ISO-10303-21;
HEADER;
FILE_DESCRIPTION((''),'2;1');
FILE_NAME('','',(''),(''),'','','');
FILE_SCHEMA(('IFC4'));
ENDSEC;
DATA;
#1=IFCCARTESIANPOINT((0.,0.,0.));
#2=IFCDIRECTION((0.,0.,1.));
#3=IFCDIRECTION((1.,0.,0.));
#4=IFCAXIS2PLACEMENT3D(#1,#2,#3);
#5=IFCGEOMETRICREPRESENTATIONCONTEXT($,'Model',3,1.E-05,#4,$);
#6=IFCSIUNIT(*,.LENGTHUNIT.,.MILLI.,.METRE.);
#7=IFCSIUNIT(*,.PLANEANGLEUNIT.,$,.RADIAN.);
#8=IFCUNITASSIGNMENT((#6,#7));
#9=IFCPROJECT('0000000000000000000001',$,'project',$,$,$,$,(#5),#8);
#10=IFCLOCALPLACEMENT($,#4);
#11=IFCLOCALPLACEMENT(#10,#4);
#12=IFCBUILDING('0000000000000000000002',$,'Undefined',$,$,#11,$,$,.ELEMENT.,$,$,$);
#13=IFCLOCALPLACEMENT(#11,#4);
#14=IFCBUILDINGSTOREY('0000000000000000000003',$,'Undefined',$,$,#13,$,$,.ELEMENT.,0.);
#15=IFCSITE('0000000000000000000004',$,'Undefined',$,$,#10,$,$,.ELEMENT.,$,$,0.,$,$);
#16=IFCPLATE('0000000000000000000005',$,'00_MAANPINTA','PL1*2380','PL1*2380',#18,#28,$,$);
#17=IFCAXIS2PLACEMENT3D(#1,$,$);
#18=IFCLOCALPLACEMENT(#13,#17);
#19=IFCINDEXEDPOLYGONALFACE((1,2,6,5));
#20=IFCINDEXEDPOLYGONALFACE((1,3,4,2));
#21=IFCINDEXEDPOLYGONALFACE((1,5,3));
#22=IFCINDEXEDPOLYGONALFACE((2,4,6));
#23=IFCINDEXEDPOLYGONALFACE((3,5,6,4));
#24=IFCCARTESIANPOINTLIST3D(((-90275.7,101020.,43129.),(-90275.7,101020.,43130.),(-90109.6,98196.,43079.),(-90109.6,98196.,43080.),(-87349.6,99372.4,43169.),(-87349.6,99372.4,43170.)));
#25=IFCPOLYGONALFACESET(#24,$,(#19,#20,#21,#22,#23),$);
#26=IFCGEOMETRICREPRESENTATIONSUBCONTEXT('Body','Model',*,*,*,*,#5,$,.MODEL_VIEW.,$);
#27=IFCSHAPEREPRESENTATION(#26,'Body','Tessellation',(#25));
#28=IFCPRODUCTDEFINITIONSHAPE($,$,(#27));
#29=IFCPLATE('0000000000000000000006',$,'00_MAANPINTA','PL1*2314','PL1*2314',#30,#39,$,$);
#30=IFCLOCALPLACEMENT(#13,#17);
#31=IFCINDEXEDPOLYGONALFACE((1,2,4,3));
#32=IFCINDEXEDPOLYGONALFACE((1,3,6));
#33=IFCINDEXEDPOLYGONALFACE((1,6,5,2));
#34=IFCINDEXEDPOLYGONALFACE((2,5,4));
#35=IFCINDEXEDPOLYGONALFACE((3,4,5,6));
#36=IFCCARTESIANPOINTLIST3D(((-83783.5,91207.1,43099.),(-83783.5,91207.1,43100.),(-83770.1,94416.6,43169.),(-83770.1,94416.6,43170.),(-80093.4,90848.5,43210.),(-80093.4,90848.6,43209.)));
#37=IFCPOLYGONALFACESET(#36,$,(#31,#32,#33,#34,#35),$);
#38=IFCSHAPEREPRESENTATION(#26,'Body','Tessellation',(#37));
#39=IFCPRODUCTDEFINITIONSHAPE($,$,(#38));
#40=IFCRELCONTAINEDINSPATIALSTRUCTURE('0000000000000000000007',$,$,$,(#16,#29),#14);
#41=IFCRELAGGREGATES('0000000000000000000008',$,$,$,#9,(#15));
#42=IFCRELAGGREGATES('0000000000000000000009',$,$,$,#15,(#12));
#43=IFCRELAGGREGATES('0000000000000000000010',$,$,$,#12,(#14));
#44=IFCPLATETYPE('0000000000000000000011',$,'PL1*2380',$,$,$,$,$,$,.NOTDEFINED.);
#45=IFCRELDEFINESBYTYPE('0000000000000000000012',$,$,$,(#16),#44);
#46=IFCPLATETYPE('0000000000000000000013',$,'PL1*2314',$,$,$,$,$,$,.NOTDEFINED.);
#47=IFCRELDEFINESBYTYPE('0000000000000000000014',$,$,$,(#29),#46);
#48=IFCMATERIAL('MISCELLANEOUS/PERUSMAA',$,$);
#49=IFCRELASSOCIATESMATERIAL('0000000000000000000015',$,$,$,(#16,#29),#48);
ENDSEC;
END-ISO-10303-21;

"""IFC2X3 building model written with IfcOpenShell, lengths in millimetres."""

from ifc_helpers import new_model, si_unit, frame, origin_with_axes, place, context, subcontext, project, spatial, polyline, outline, extrude, material, type_object, element, save


model = new_model("IFC2X3")

# Units and contexts
model_context = context("Model", 3, precision=1e-05, world=origin_with_axes())
body_context = subcontext(model_context, "Body", "Model", "MODEL_VIEW")
ifc_project = project(units=[si_unit("LENGTHUNIT", "METRE", prefix="MILLI"), si_unit("PLANEANGLEUNIT", "RADIAN")], contexts=[model_context])

# Site, building, storey
site_placement = place(None, origin_with_axes())
site = spatial("IfcSite", under=ifc_project, at=site_placement, Name="Undefined", CompositionType="ELEMENT", RefElevation=0.0)
building_placement = place(site_placement, origin_with_axes())
building = spatial("IfcBuilding", under=site, at=building_placement, Name="Undefined", CompositionType="ELEMENT")
storey_placement = place(building_placement, origin_with_axes())
storey = spatial("IfcBuildingStorey", under=building, at=storey_placement, Name="Undefined", CompositionType="ELEMENT", Elevation=0.0)

# Plates
ifc_material = material(Name="MISCELLANEOUS/PERUSMAA")
plate_type_1 = type_object("IfcPlateType", Name="PL1*2380", PredefinedType="NOTDEFINED")
plate_1_placement = place(storey_placement, frame((-90275.7, 101020.0, 43129.5), z_axis=(0.024437, 0.019134, -0.999518), x_axis=(0.871302, -0.490602, 0.011911)))
element("IfcPlate", 1, at=plate_1_placement, inside=storey, type_object=plate_type_1, material=ifc_material, Name="00_MAANPINTA", Description="PL1*2380", ObjectType="PL1*2380", context=body_context, shape_type="SweptSolid", body=[
    extrude(outline(polyline([(0.0, 0.0), (3358.2, 0.0), (1529.5, 2380.2), (0.0, 0.0)])), frame((0.0, 0.0, -0.5), z_axis=(0.0, 0.0, 1.0), x_axis=(1.0, 0.0, 0.0)), (0.0, 0.0, 1.0), 1.0),
])
plate_type_2 = type_object("IfcPlateType", Name="PL1*2314", PredefinedType="NOTDEFINED")
plate_2_placement = place(storey_placement, frame((-83770.1, 94416.6, 43169.5), z_axis=(0.031892, 0.021661, -0.999257), x_axis=(0.717607, -0.696404, 0.007807)))
element("IfcPlate", 2, at=plate_2_placement, inside=storey, type_object=plate_type_2, material=ifc_material, Name="00_MAANPINTA", Description="PL1*2314", ObjectType="PL1*2314", context=body_context, shape_type="SweptSolid", body=[
    extrude(outline(polyline([(0.0, 0.0), (5123.5, 0.0), (2224.9, 2314.2), (0.0, 0.0)])), frame((0.0, 0.0, -0.5), z_axis=(0.0, 0.0, 1.0), x_axis=(1.0, 0.0, 0.0)), (0.0, 0.0, 1.0), 1.0),
])

save(model, "model.ifc")
